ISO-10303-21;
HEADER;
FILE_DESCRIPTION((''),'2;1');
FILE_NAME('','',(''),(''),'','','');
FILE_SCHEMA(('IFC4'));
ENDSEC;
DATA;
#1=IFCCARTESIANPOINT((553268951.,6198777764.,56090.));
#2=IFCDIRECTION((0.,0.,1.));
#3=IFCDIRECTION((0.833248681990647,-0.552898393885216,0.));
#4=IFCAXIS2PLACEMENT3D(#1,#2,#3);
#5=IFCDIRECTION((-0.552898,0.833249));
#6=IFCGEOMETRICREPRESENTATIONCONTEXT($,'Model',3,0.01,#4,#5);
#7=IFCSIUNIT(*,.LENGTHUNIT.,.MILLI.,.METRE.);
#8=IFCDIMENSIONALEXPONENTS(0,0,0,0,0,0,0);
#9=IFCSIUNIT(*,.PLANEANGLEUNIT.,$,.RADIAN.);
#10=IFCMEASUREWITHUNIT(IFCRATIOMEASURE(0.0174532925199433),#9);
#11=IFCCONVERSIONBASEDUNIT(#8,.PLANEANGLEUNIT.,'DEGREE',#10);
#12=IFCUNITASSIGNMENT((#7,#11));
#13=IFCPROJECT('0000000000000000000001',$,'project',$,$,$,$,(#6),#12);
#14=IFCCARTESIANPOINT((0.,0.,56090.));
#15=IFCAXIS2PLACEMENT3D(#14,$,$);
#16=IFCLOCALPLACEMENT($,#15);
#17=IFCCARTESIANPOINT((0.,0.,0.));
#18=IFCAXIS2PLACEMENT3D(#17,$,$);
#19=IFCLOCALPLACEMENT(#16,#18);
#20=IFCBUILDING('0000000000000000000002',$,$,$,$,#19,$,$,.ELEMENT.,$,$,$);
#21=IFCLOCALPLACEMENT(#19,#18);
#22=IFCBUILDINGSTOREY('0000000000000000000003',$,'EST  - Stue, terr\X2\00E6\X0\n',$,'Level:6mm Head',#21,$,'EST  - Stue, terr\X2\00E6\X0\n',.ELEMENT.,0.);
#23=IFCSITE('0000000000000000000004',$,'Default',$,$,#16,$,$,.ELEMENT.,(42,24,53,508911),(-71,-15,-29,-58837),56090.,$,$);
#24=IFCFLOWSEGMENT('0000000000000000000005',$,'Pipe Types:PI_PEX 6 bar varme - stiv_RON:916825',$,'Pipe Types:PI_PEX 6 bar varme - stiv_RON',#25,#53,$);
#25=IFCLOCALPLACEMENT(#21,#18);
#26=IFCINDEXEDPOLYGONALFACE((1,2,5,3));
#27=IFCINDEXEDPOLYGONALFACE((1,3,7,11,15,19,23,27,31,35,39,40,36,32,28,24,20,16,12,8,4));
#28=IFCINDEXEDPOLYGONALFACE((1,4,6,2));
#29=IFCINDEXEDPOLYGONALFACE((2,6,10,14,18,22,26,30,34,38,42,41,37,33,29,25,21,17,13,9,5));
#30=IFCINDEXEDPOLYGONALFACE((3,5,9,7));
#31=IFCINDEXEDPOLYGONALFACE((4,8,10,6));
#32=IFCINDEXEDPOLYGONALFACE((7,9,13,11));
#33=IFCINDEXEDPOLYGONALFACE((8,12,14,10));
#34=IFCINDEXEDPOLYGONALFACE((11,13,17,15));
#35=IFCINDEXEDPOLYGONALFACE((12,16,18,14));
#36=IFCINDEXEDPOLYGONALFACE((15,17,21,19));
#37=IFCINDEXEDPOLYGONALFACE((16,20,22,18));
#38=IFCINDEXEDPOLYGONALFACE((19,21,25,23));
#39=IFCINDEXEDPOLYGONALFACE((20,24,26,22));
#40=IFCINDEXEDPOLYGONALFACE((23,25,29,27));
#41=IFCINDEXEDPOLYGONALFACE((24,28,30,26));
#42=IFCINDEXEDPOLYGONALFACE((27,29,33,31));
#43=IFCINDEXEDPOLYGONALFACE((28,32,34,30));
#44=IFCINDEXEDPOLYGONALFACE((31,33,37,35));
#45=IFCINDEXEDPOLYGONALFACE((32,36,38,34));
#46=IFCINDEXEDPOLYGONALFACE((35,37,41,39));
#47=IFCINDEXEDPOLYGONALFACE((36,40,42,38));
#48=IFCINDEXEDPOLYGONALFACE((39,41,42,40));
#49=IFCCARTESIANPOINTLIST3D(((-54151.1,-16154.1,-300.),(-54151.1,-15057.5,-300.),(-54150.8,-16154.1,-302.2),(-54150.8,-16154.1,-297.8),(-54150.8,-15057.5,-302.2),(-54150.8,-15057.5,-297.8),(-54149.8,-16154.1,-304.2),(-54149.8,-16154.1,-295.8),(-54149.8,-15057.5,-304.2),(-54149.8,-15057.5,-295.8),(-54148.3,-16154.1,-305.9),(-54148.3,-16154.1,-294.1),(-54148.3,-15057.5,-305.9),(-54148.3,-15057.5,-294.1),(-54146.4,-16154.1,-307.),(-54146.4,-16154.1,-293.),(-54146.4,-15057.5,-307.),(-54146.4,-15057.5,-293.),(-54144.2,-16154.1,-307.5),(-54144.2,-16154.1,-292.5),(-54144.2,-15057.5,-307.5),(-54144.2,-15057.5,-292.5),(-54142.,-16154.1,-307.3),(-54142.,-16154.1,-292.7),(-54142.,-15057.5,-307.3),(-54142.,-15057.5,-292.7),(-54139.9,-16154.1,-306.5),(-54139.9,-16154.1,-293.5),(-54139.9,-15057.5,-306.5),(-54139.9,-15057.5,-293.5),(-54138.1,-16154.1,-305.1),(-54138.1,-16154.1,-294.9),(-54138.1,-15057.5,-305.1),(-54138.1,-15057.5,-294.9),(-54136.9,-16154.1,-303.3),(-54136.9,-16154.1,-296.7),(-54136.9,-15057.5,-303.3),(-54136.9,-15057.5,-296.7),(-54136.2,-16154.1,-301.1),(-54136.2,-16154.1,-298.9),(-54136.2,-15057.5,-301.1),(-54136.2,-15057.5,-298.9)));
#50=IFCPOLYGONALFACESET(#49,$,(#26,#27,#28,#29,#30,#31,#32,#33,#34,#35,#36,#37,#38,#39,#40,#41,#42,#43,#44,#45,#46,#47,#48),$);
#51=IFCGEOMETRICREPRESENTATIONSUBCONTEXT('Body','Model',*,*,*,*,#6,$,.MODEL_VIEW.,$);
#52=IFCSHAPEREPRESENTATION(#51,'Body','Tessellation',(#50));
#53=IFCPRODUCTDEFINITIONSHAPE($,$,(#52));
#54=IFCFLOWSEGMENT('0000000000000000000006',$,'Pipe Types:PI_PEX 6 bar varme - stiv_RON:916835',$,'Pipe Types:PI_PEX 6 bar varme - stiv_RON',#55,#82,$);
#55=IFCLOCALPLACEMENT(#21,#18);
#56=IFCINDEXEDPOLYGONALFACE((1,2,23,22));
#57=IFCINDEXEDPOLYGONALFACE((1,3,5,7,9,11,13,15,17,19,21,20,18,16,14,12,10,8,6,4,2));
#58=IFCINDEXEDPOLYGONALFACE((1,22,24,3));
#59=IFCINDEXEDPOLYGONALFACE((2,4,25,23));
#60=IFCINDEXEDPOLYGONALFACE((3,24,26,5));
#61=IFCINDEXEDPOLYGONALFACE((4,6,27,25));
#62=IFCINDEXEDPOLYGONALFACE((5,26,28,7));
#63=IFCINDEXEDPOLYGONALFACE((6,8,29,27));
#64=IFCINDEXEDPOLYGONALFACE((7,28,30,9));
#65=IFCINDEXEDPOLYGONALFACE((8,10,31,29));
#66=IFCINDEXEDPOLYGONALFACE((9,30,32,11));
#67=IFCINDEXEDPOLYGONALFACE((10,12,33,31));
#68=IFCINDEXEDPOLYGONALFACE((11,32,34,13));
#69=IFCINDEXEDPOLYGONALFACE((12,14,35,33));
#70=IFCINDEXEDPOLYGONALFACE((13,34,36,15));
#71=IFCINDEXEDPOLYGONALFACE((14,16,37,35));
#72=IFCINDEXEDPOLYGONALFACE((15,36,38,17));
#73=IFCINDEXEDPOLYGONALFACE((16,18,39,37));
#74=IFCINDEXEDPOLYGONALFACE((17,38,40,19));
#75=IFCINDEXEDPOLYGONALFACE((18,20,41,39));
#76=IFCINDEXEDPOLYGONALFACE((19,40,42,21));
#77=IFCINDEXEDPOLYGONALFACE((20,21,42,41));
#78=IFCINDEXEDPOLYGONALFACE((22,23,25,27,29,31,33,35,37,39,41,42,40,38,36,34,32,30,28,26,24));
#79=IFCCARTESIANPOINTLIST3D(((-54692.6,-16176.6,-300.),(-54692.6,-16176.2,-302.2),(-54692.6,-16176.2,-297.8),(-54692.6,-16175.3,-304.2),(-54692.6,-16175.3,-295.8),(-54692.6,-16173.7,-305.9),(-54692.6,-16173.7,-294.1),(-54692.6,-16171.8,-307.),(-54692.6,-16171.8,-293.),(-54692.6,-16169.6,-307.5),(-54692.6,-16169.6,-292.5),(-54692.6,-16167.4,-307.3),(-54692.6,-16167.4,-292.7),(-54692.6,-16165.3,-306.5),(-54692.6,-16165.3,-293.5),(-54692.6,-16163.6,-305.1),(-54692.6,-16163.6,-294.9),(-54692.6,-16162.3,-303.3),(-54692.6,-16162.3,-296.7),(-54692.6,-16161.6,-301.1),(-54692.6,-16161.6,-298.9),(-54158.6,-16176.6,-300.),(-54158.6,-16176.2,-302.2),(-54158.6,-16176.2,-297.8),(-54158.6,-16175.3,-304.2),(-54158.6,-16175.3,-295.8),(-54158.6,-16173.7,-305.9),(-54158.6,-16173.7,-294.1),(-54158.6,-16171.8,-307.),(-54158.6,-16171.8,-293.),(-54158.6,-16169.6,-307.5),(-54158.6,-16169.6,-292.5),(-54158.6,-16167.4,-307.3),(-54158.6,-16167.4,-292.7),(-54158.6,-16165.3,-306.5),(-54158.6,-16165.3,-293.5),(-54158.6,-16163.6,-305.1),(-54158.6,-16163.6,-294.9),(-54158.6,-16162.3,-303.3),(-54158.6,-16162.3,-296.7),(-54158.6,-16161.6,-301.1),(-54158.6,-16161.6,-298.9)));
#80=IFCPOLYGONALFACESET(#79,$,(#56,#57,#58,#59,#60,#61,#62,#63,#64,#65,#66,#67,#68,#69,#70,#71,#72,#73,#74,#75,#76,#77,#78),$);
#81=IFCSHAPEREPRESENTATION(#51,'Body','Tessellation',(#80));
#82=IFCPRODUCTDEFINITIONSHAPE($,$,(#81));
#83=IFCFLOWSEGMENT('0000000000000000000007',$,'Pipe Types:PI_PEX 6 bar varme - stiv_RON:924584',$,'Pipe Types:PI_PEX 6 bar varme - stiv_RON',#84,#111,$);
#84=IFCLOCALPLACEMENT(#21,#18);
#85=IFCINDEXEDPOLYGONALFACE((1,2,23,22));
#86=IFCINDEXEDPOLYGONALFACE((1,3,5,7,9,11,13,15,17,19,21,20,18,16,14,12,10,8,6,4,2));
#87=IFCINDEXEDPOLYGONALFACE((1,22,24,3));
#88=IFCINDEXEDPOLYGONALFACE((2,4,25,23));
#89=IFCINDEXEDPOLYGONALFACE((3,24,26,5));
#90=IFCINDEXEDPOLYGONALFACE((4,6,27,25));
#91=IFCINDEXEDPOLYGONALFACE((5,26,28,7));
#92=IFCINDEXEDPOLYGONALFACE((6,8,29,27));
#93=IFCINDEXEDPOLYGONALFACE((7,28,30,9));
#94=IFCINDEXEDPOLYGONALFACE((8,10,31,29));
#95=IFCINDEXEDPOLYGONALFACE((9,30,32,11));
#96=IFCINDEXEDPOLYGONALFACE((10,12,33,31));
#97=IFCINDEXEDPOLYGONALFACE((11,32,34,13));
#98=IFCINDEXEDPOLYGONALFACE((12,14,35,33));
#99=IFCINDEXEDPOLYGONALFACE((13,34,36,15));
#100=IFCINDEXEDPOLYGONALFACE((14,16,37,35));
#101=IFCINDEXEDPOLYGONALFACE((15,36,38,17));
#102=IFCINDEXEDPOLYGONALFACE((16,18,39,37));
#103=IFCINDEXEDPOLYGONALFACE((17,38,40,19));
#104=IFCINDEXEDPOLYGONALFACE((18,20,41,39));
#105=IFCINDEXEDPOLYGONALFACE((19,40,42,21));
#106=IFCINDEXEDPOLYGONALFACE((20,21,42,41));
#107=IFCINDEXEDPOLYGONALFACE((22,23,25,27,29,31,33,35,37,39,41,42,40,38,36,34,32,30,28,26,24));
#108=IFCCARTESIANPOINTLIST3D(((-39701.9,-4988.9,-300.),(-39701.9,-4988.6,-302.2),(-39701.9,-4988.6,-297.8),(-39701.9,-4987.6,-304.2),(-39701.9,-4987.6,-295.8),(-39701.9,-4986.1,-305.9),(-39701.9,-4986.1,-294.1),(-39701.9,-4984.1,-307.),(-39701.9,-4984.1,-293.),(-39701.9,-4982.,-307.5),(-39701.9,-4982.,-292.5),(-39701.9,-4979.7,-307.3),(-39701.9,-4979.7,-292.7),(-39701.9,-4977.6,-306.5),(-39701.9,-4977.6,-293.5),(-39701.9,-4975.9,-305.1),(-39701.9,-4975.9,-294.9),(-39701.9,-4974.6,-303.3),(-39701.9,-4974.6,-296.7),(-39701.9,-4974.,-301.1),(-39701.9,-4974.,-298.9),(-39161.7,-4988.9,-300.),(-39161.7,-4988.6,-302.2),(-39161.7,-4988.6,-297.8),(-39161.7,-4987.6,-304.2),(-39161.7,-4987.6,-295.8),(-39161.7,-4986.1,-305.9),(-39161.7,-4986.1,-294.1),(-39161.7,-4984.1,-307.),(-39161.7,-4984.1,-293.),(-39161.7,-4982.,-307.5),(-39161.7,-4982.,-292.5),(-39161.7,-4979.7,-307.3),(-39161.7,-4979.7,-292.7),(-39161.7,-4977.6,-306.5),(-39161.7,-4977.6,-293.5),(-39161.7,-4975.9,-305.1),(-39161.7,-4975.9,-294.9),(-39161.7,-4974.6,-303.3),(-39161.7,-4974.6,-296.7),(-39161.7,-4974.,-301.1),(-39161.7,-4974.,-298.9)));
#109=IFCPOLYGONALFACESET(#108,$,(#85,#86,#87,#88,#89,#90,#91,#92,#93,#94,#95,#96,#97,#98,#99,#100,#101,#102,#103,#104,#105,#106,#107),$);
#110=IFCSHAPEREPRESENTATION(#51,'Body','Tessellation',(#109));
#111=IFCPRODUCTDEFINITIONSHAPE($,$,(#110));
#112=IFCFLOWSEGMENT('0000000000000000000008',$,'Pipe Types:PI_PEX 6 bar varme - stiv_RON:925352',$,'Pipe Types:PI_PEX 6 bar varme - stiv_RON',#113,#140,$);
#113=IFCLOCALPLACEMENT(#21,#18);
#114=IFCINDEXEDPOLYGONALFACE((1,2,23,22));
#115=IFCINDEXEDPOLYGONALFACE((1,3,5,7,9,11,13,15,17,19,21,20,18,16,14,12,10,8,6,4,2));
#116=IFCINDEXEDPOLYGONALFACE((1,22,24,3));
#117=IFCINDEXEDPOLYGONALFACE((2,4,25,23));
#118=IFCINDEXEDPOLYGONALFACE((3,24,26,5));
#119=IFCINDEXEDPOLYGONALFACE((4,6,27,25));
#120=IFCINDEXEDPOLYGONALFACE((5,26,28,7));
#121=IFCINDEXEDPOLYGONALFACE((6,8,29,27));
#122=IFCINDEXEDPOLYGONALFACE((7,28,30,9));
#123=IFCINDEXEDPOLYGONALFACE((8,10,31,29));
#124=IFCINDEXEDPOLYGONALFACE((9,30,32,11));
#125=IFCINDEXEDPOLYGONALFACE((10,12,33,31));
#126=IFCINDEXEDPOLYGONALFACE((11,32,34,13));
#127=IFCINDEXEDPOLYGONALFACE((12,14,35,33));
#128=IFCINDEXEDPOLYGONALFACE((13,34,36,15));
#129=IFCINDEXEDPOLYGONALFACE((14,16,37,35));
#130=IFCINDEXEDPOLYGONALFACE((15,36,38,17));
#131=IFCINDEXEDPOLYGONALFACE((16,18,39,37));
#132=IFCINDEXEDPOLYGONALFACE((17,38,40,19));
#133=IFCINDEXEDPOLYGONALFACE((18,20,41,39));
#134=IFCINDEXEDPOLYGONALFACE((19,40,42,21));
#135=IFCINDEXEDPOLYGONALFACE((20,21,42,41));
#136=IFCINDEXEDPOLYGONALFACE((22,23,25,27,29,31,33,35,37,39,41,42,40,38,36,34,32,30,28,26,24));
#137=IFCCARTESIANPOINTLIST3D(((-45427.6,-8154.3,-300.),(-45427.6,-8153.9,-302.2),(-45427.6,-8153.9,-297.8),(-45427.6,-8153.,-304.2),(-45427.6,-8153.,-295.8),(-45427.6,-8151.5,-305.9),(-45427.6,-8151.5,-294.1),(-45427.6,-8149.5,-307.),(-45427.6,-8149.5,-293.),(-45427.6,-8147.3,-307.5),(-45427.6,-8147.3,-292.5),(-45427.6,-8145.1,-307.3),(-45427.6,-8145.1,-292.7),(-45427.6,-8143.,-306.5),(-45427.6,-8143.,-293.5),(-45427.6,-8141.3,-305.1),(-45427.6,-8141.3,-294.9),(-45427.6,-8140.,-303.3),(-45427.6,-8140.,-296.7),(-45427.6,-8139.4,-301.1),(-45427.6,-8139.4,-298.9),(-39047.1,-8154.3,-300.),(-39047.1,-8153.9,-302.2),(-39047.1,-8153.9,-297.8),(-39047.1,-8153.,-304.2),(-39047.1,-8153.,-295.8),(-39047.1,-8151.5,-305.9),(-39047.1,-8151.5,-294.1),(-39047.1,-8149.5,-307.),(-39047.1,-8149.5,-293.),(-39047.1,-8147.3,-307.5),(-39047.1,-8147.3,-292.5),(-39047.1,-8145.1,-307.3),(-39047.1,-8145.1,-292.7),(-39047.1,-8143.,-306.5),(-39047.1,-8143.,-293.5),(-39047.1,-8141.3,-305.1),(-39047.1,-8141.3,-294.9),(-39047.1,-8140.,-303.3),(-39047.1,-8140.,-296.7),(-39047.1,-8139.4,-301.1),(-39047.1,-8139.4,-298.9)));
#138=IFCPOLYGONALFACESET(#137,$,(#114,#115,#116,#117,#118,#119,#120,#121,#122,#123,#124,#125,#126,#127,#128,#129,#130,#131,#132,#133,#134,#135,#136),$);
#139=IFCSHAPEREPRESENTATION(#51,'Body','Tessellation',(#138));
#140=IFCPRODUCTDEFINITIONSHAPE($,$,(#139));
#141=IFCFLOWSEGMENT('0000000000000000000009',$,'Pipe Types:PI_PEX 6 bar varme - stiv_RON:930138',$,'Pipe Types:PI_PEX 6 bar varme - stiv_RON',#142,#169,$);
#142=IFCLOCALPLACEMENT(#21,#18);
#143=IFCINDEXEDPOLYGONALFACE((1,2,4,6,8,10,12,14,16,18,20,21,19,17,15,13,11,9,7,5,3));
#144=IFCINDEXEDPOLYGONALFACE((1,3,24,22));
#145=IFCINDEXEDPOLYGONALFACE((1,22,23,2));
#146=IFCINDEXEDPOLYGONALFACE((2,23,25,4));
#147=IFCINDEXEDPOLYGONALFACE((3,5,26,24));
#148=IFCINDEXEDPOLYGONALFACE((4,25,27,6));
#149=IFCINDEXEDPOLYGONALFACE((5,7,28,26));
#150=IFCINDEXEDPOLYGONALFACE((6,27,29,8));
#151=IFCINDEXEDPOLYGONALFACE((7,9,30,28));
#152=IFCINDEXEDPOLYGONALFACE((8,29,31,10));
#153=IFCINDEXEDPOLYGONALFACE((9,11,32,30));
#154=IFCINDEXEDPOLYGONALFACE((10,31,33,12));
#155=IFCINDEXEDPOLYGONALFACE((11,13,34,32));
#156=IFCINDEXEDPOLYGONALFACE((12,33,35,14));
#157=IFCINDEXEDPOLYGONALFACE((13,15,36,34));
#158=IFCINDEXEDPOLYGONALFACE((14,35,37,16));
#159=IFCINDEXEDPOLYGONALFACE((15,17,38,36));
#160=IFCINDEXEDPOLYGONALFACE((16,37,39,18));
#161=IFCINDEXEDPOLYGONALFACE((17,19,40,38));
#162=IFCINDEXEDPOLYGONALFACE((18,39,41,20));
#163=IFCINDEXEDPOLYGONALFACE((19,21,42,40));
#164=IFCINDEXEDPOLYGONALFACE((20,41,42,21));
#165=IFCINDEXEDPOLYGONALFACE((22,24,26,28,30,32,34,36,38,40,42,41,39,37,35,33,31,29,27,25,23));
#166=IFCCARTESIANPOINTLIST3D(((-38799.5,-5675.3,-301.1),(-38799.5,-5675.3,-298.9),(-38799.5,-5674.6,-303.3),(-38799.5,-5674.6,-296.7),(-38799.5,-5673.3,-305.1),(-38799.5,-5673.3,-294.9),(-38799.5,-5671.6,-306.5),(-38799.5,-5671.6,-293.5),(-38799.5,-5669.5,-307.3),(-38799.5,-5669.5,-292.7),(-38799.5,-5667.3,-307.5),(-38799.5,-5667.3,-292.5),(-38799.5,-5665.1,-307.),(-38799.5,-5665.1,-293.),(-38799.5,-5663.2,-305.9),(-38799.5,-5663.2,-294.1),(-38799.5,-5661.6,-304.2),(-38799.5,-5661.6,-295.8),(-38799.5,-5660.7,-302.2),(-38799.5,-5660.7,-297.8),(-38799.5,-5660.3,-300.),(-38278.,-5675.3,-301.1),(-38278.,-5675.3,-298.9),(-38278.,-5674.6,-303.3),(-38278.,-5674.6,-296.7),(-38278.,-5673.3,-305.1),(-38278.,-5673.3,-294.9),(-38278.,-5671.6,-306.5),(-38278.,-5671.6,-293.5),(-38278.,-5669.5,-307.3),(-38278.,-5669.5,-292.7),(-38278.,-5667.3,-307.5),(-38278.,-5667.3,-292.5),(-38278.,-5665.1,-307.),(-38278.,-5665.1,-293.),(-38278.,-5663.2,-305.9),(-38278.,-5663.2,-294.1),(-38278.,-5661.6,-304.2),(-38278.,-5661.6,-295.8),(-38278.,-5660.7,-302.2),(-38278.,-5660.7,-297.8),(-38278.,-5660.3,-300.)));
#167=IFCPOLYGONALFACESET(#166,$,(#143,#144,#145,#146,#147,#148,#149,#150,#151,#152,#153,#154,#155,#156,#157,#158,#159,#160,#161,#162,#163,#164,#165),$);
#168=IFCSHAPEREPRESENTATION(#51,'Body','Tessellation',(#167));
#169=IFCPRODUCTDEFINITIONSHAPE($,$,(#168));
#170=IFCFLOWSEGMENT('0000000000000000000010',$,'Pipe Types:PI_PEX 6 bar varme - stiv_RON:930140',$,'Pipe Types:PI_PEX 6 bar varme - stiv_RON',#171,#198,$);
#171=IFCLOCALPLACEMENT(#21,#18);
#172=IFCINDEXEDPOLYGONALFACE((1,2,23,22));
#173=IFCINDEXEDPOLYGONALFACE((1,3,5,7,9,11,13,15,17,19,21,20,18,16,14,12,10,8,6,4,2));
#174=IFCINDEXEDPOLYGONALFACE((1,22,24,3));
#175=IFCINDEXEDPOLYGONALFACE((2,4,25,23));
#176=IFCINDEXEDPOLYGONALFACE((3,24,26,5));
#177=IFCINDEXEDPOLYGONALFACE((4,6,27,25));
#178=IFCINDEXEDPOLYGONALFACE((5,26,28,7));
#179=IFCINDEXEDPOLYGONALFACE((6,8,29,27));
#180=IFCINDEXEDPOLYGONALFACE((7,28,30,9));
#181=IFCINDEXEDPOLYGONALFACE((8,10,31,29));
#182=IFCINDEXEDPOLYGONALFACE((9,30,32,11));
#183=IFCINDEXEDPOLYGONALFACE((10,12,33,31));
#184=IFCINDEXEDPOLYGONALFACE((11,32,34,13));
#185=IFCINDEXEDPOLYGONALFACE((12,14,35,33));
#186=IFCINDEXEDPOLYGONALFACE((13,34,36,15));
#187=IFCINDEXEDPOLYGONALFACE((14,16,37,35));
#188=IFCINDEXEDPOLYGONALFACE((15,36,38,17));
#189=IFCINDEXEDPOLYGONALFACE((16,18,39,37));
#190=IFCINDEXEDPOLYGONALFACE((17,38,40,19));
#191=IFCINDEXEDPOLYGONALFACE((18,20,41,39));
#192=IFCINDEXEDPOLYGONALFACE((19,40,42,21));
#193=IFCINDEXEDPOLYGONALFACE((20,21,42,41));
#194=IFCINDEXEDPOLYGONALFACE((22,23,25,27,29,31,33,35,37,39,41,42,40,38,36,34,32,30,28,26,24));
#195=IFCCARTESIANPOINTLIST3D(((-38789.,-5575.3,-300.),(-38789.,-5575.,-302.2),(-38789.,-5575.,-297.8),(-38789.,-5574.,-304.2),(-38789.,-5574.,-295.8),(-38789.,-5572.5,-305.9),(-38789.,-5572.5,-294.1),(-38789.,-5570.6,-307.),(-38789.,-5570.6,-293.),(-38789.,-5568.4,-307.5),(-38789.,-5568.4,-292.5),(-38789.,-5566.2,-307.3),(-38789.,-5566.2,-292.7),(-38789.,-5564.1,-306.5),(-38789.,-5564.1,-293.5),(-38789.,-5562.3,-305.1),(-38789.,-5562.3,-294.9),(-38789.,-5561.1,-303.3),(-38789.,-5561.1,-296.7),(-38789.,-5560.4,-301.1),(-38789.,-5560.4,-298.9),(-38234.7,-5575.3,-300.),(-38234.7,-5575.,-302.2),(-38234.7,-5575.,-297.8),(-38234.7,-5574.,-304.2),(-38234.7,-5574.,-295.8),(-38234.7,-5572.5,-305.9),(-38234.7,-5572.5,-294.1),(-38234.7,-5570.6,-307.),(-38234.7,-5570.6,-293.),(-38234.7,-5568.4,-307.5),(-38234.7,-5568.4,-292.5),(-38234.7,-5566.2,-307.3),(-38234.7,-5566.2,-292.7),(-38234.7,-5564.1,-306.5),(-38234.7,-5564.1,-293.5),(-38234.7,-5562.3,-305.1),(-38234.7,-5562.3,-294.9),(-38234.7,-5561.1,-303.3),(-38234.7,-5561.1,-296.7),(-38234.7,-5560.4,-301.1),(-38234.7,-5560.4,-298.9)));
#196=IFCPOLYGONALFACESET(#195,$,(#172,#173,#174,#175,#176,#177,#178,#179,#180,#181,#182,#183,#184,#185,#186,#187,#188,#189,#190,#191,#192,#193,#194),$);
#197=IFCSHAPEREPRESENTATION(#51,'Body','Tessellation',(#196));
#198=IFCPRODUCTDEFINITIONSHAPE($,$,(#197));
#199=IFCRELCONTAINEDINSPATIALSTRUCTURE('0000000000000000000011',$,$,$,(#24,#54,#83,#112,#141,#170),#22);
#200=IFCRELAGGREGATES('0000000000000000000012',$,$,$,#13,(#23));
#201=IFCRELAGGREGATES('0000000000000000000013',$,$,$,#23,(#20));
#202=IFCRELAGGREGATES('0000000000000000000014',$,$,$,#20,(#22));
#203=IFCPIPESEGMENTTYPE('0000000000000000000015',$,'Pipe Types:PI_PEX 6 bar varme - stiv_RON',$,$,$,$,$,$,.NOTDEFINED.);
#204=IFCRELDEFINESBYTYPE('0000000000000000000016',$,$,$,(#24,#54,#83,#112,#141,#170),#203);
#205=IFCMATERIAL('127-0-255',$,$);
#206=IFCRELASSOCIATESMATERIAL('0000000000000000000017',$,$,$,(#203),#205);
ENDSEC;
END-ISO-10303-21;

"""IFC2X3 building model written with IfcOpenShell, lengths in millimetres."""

from ifc_helpers import new_model, entity, si_unit, converted_unit, direction, frame, frame_2d, origin, origin_2d_with_axis, place, context, subcontext, project, spatial, circle, extrude, material, type_object, element, save


model = new_model("IFC2X3")

# Units and contexts
model_context = context("Model", 3, precision=0.01, world=frame((553268951.0, 6198777764.0, 56090.0), z_axis=(0.0, 0.0, 1.0), x_axis=(0.833248681990647, -0.552898393885216, 0.0)), true_north=direction((-0.552898, 0.833249)))
body_context = subcontext(model_context, "Body", "Model", "MODEL_VIEW")
ifc_project = project(units=[si_unit("LENGTHUNIT", "METRE", prefix="MILLI"), converted_unit("PLANEANGLEUNIT", "DEGREE", entity("IfcRatioMeasure", 0.0174532925199433), si_unit("PLANEANGLEUNIT", "RADIAN"), dimensions=[0, 0, 0, 0, 0, 0, 0])], contexts=[model_context])

# Site, building, storey
site_placement = place(None, frame((0.0, 0.0, 56090.0)))
site = spatial("IfcSite", under=ifc_project, at=site_placement, Name="Default", CompositionType="ELEMENT", RefLatitude=(42, 24, 53, 508911), RefLongitude=(-71, -15, -29, -58837), RefElevation=56090.0)
building_placement = place(site_placement, origin())
building = spatial("IfcBuilding", under=site, at=building_placement, CompositionType="ELEMENT")
storey_placement = place(building_placement, frame((0.0, 0.0, 0.0)))
storey = spatial("IfcBuildingStorey", under=building, at=storey_placement, Name="EST  - Stue, terræn", ObjectType="Level:6mm Head", LongName="EST  - Stue, terræn", CompositionType="ELEMENT", Elevation=0.0)

# Flow segments
ifc_material_1 = material(Name="127-0-255")
pipe_segment_type_1 = type_object("IfcPipeSegmentType", Name="Pipe Types:PI_PEX 6 bar varme - stiv_RON", PredefinedType="NOTDEFINED", material=ifc_material_1)
flow_segment_1_placement = place(storey_placement, origin())
element("IfcFlowSegment", 1, at=flow_segment_1_placement, inside=storey, type_object=pipe_segment_type_1, Name="Pipe Types:PI_PEX 6 bar varme - stiv_RON:916825", ObjectType="Pipe Types:PI_PEX 6 bar varme - stiv_RON", context=body_context, shape_type="SweptSolid", body=[
    extrude(circle(Radius=7.5, at=frame_2d((0.0, 0.0), x_axis=(1.0, 0.0))), frame((-54143.6, -16154.1, -300.0), z_axis=(0.0, 1.0, 0.0), x_axis=(-1.0, 0.0, 0.0)), (0.0, 0.0, 1.0), 1096.5),
])
flow_segment_2_placement = place(storey_placement, origin())
element("IfcFlowSegment", 2, at=flow_segment_2_placement, inside=storey, type_object=pipe_segment_type_1, Name="Pipe Types:PI_PEX 6 bar varme - stiv_RON:916835", ObjectType="Pipe Types:PI_PEX 6 bar varme - stiv_RON", context=body_context, shape_type="SweptSolid", body=[
    extrude(circle(Radius=7.5, at=origin_2d_with_axis()), frame((-54692.6, -16169.1, -300.0), z_axis=(1.0, 0.0, 0.0), x_axis=(0.0, -1.0, 0.0)), (0.0, 0.0, 1.0), 534.0),
])
flow_segment_3_placement = place(storey_placement, origin())
element("IfcFlowSegment", 3, at=flow_segment_3_placement, inside=storey, type_object=pipe_segment_type_1, Name="Pipe Types:PI_PEX 6 bar varme - stiv_RON:924584", ObjectType="Pipe Types:PI_PEX 6 bar varme - stiv_RON", context=body_context, shape_type="SweptSolid", body=[
    extrude(circle(Radius=7.5, at=origin_2d_with_axis()), frame((-39701.9, -4981.4, -300.0), z_axis=(1.0, 0.0, 0.0), x_axis=(0.0, -1.0, 0.0)), (0.0, 0.0, 1.0), 540.2),
])
flow_segment_4_placement = place(storey_placement, origin())
element("IfcFlowSegment", 4, at=flow_segment_4_placement, inside=storey, type_object=pipe_segment_type_1, Name="Pipe Types:PI_PEX 6 bar varme - stiv_RON:925352", ObjectType="Pipe Types:PI_PEX 6 bar varme - stiv_RON", context=body_context, shape_type="SweptSolid", body=[
    extrude(circle(Radius=7.5, at=origin_2d_with_axis()), frame((-45427.6, -8146.8, -300.0), z_axis=(1.0, 0.0, 0.0), x_axis=(0.0, -1.0, 0.0)), (0.0, 0.0, 1.0), 6380.5),
])
flow_segment_5_placement = place(storey_placement, origin())
element("IfcFlowSegment", 5, at=flow_segment_5_placement, inside=storey, type_object=pipe_segment_type_1, Name="Pipe Types:PI_PEX 6 bar varme - stiv_RON:930138", ObjectType="Pipe Types:PI_PEX 6 bar varme - stiv_RON", context=body_context, shape_type="SweptSolid", body=[
    extrude(circle(Radius=7.5, at=origin_2d_with_axis()), frame((-38799.5, -5667.8, -300.0), z_axis=(1.0, 0.0, 0.0), x_axis=(0.0, 1.0, 0.0)), (0.0, 0.0, 1.0), 521.5),
])
flow_segment_6_placement = place(storey_placement, origin())
element("IfcFlowSegment", 6, at=flow_segment_6_placement, inside=storey, type_object=pipe_segment_type_1, Name="Pipe Types:PI_PEX 6 bar varme - stiv_RON:930140", ObjectType="Pipe Types:PI_PEX 6 bar varme - stiv_RON", context=body_context, shape_type="SweptSolid", body=[
    extrude(circle(Radius=7.5, at=origin_2d_with_axis()), frame((-38789.0, -5567.8, -300.0), z_axis=(1.0, 0.0, 0.0), x_axis=(0.0, -1.0, 0.0)), (0.0, 0.0, 1.0), 554.3),
])

save(model, "model.ifc")
